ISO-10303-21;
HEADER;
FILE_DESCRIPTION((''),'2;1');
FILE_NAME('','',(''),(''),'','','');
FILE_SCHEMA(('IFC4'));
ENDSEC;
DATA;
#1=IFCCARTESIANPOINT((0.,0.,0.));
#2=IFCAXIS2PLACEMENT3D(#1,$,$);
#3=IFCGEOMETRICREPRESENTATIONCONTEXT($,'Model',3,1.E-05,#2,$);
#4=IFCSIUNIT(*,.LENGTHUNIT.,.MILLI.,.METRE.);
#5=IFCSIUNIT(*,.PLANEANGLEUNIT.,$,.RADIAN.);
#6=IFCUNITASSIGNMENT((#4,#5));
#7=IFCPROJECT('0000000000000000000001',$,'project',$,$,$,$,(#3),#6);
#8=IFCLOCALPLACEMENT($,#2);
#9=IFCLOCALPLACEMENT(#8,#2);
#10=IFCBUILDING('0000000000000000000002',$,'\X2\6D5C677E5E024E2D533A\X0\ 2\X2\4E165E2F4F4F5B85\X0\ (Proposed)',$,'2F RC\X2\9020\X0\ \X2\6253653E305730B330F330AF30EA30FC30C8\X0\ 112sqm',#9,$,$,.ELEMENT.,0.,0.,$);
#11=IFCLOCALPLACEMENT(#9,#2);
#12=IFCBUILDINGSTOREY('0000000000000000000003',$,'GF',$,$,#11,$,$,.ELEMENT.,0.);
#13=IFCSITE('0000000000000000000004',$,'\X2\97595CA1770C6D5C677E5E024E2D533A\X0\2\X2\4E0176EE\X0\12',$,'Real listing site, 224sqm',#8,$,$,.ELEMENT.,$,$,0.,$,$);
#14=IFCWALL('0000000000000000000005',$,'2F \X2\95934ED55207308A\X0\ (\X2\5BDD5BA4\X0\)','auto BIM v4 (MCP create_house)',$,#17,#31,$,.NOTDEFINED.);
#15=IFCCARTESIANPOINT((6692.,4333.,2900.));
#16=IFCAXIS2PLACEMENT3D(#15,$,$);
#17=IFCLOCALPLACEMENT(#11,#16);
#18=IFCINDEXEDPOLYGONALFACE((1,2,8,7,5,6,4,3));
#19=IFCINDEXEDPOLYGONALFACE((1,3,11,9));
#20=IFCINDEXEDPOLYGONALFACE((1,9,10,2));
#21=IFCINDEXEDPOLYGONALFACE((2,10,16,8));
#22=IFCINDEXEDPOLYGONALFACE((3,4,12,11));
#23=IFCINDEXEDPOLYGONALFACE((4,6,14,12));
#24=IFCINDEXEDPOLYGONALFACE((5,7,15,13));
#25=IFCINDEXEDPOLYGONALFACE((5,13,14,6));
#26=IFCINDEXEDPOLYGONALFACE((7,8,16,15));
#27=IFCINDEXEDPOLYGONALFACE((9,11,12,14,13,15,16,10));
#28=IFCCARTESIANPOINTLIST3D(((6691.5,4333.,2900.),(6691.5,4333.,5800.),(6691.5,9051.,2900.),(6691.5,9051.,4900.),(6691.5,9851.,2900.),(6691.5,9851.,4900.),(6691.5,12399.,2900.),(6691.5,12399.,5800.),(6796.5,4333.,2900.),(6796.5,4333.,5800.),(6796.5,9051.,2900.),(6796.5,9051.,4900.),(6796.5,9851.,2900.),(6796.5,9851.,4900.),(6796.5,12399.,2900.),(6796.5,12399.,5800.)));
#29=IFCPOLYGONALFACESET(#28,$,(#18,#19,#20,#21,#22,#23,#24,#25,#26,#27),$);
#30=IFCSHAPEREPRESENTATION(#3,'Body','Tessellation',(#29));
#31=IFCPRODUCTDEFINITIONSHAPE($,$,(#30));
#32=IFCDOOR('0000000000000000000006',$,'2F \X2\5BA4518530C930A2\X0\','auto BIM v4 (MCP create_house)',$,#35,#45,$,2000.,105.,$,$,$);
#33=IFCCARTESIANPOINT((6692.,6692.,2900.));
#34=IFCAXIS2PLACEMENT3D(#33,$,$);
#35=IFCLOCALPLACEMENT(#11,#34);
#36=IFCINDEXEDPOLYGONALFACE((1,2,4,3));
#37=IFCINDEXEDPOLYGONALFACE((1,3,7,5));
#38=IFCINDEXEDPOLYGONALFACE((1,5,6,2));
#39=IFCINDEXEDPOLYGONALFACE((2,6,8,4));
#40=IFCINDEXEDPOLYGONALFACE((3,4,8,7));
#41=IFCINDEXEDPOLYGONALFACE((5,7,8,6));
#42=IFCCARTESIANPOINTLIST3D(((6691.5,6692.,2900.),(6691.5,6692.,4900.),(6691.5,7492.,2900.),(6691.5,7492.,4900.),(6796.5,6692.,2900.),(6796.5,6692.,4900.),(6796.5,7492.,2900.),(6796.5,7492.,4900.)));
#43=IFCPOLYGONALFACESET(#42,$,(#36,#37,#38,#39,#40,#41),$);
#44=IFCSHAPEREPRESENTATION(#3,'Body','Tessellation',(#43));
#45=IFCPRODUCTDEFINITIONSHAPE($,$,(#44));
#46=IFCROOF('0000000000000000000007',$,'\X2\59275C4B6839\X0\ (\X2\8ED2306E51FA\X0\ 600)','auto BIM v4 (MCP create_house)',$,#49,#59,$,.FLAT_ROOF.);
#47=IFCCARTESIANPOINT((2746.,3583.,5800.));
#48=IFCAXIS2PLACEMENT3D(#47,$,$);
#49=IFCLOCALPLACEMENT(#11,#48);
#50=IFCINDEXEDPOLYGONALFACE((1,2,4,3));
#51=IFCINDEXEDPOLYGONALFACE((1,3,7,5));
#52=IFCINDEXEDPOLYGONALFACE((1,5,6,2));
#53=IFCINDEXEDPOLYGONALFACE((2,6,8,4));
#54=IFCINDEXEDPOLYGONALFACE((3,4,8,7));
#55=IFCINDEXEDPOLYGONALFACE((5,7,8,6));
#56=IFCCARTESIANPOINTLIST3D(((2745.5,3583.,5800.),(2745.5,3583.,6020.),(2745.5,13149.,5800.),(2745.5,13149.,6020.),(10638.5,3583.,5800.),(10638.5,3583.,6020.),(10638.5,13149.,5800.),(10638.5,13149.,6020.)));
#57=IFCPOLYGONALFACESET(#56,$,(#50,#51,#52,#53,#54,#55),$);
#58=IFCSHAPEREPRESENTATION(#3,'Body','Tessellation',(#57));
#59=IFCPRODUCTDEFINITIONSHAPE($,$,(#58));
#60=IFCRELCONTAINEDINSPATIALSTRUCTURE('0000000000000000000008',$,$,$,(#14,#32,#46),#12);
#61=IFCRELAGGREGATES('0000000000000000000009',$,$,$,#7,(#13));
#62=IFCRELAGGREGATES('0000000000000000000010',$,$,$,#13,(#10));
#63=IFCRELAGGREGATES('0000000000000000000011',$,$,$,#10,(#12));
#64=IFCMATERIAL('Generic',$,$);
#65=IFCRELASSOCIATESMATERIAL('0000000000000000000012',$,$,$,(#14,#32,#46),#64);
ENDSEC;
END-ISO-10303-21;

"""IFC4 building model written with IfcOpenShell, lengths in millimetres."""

from ifc_helpers import new_model, si_unit, frame, frame_2d, origin, place, context, project, spatial, rectangle, extrude, material, element, fill, save


model = new_model("IFC4")

# Units and contexts
model_context = context("Model", 3, precision=1e-05, world=origin())
ifc_project = project(units=[si_unit("LENGTHUNIT", "METRE", prefix="MILLI"), si_unit("PLANEANGLEUNIT", "RADIAN")], contexts=[model_context])

# Site, building, storey
site_placement = place(None, origin())
site = spatial("IfcSite", under=ifc_project, at=site_placement, Name="静岡県浜松市中区2丁目12", ObjectType="Real listing site, 224sqm", CompositionType="ELEMENT", RefElevation=0.0)
building_placement = place(site_placement, origin())
building = spatial("IfcBuilding", under=site, at=building_placement, Name="浜松市中区 2世帯住宅 (Proposed)", ObjectType="2F RC造 打放しコンクリート 112sqm", CompositionType="ELEMENT", ElevationOfRefHeight=0.0, ElevationOfTerrain=0.0)
storey_placement = place(building_placement, origin())
storey = spatial("IfcBuildingStorey", under=building, at=storey_placement, Name="GF", CompositionType="ELEMENT", Elevation=0.0)

# Shared definitions
ifc_material = material(Name="Generic")

# Wall, opening, door
wall_1_placement = place(storey_placement, frame((6692.0, 4333.0, 2900.0)))
wall_1 = element("IfcWall", 1, at=wall_1_placement, inside=storey, material=ifc_material, Name="2F 間仕切り (寝室)", Description="auto BIM v4 (MCP create_house)", PredefinedType="NOTDEFINED", context=model_context, shape_type="SweptSolid", body=[
    extrude(rectangle(XDim=105.0, YDim=8066.0, at=frame_2d((52.0, 4033.0))), frame((6692.0, 4333.0, 2900.0)), (0.0, 0.0, 1.0), 2900.0),
])
opening_1_placement = place(storey_placement, frame((6692.0, 6692.0, 2900.0)))
opening_1 = element("IfcOpeningElement", 2, at=opening_1_placement, cuts=wall_1, PredefinedType="NOTDEFINED", context=model_context, shape_type="SweptSolid", body=[
    extrude(rectangle(XDim=105.0, YDim=800.0, at=frame_2d((52.0, 400.0))), frame((6692.0, 6692.0, 2900.0)), (0.0, 0.0, 1.0), 2000.0),
])
door_1_placement = place(storey_placement, frame((6692.0, 6692.0, 2900.0)))
door_1 = element("IfcDoor", 3, at=door_1_placement, inside=storey, material=ifc_material, Name="2F 室内ドア", Description="auto BIM v4 (MCP create_house)", OverallHeight=2000.0, OverallWidth=105.0, context=model_context, shape_type="SweptSolid", body=[
    extrude(rectangle(XDim=105.0, YDim=800.0, at=frame_2d((52.0, 400.0))), frame((6692.0, 6692.0, 2900.0)), (0.0, 0.0, 1.0), 2000.0),
])
fill(opening_1, door_1)

# Roof
roof_placement = place(storey_placement, frame((2746.0, 3583.0, 5800.0)))
element("IfcRoof", 4, at=roof_placement, inside=storey, material=ifc_material, Name="大屋根 (軒の出 600)", Description="auto BIM v4 (MCP create_house)", PredefinedType="FLAT_ROOF", context=model_context, shape_type="SweptSolid", body=[
    extrude(rectangle(XDim=7893.0, YDim=9566.0, at=frame_2d((3946.0, 4783.0))), frame((2746.0, 3583.0, 5800.0)), (0.0, 0.0, 1.0), 220.0),
])

save(model, "model.ifc")
